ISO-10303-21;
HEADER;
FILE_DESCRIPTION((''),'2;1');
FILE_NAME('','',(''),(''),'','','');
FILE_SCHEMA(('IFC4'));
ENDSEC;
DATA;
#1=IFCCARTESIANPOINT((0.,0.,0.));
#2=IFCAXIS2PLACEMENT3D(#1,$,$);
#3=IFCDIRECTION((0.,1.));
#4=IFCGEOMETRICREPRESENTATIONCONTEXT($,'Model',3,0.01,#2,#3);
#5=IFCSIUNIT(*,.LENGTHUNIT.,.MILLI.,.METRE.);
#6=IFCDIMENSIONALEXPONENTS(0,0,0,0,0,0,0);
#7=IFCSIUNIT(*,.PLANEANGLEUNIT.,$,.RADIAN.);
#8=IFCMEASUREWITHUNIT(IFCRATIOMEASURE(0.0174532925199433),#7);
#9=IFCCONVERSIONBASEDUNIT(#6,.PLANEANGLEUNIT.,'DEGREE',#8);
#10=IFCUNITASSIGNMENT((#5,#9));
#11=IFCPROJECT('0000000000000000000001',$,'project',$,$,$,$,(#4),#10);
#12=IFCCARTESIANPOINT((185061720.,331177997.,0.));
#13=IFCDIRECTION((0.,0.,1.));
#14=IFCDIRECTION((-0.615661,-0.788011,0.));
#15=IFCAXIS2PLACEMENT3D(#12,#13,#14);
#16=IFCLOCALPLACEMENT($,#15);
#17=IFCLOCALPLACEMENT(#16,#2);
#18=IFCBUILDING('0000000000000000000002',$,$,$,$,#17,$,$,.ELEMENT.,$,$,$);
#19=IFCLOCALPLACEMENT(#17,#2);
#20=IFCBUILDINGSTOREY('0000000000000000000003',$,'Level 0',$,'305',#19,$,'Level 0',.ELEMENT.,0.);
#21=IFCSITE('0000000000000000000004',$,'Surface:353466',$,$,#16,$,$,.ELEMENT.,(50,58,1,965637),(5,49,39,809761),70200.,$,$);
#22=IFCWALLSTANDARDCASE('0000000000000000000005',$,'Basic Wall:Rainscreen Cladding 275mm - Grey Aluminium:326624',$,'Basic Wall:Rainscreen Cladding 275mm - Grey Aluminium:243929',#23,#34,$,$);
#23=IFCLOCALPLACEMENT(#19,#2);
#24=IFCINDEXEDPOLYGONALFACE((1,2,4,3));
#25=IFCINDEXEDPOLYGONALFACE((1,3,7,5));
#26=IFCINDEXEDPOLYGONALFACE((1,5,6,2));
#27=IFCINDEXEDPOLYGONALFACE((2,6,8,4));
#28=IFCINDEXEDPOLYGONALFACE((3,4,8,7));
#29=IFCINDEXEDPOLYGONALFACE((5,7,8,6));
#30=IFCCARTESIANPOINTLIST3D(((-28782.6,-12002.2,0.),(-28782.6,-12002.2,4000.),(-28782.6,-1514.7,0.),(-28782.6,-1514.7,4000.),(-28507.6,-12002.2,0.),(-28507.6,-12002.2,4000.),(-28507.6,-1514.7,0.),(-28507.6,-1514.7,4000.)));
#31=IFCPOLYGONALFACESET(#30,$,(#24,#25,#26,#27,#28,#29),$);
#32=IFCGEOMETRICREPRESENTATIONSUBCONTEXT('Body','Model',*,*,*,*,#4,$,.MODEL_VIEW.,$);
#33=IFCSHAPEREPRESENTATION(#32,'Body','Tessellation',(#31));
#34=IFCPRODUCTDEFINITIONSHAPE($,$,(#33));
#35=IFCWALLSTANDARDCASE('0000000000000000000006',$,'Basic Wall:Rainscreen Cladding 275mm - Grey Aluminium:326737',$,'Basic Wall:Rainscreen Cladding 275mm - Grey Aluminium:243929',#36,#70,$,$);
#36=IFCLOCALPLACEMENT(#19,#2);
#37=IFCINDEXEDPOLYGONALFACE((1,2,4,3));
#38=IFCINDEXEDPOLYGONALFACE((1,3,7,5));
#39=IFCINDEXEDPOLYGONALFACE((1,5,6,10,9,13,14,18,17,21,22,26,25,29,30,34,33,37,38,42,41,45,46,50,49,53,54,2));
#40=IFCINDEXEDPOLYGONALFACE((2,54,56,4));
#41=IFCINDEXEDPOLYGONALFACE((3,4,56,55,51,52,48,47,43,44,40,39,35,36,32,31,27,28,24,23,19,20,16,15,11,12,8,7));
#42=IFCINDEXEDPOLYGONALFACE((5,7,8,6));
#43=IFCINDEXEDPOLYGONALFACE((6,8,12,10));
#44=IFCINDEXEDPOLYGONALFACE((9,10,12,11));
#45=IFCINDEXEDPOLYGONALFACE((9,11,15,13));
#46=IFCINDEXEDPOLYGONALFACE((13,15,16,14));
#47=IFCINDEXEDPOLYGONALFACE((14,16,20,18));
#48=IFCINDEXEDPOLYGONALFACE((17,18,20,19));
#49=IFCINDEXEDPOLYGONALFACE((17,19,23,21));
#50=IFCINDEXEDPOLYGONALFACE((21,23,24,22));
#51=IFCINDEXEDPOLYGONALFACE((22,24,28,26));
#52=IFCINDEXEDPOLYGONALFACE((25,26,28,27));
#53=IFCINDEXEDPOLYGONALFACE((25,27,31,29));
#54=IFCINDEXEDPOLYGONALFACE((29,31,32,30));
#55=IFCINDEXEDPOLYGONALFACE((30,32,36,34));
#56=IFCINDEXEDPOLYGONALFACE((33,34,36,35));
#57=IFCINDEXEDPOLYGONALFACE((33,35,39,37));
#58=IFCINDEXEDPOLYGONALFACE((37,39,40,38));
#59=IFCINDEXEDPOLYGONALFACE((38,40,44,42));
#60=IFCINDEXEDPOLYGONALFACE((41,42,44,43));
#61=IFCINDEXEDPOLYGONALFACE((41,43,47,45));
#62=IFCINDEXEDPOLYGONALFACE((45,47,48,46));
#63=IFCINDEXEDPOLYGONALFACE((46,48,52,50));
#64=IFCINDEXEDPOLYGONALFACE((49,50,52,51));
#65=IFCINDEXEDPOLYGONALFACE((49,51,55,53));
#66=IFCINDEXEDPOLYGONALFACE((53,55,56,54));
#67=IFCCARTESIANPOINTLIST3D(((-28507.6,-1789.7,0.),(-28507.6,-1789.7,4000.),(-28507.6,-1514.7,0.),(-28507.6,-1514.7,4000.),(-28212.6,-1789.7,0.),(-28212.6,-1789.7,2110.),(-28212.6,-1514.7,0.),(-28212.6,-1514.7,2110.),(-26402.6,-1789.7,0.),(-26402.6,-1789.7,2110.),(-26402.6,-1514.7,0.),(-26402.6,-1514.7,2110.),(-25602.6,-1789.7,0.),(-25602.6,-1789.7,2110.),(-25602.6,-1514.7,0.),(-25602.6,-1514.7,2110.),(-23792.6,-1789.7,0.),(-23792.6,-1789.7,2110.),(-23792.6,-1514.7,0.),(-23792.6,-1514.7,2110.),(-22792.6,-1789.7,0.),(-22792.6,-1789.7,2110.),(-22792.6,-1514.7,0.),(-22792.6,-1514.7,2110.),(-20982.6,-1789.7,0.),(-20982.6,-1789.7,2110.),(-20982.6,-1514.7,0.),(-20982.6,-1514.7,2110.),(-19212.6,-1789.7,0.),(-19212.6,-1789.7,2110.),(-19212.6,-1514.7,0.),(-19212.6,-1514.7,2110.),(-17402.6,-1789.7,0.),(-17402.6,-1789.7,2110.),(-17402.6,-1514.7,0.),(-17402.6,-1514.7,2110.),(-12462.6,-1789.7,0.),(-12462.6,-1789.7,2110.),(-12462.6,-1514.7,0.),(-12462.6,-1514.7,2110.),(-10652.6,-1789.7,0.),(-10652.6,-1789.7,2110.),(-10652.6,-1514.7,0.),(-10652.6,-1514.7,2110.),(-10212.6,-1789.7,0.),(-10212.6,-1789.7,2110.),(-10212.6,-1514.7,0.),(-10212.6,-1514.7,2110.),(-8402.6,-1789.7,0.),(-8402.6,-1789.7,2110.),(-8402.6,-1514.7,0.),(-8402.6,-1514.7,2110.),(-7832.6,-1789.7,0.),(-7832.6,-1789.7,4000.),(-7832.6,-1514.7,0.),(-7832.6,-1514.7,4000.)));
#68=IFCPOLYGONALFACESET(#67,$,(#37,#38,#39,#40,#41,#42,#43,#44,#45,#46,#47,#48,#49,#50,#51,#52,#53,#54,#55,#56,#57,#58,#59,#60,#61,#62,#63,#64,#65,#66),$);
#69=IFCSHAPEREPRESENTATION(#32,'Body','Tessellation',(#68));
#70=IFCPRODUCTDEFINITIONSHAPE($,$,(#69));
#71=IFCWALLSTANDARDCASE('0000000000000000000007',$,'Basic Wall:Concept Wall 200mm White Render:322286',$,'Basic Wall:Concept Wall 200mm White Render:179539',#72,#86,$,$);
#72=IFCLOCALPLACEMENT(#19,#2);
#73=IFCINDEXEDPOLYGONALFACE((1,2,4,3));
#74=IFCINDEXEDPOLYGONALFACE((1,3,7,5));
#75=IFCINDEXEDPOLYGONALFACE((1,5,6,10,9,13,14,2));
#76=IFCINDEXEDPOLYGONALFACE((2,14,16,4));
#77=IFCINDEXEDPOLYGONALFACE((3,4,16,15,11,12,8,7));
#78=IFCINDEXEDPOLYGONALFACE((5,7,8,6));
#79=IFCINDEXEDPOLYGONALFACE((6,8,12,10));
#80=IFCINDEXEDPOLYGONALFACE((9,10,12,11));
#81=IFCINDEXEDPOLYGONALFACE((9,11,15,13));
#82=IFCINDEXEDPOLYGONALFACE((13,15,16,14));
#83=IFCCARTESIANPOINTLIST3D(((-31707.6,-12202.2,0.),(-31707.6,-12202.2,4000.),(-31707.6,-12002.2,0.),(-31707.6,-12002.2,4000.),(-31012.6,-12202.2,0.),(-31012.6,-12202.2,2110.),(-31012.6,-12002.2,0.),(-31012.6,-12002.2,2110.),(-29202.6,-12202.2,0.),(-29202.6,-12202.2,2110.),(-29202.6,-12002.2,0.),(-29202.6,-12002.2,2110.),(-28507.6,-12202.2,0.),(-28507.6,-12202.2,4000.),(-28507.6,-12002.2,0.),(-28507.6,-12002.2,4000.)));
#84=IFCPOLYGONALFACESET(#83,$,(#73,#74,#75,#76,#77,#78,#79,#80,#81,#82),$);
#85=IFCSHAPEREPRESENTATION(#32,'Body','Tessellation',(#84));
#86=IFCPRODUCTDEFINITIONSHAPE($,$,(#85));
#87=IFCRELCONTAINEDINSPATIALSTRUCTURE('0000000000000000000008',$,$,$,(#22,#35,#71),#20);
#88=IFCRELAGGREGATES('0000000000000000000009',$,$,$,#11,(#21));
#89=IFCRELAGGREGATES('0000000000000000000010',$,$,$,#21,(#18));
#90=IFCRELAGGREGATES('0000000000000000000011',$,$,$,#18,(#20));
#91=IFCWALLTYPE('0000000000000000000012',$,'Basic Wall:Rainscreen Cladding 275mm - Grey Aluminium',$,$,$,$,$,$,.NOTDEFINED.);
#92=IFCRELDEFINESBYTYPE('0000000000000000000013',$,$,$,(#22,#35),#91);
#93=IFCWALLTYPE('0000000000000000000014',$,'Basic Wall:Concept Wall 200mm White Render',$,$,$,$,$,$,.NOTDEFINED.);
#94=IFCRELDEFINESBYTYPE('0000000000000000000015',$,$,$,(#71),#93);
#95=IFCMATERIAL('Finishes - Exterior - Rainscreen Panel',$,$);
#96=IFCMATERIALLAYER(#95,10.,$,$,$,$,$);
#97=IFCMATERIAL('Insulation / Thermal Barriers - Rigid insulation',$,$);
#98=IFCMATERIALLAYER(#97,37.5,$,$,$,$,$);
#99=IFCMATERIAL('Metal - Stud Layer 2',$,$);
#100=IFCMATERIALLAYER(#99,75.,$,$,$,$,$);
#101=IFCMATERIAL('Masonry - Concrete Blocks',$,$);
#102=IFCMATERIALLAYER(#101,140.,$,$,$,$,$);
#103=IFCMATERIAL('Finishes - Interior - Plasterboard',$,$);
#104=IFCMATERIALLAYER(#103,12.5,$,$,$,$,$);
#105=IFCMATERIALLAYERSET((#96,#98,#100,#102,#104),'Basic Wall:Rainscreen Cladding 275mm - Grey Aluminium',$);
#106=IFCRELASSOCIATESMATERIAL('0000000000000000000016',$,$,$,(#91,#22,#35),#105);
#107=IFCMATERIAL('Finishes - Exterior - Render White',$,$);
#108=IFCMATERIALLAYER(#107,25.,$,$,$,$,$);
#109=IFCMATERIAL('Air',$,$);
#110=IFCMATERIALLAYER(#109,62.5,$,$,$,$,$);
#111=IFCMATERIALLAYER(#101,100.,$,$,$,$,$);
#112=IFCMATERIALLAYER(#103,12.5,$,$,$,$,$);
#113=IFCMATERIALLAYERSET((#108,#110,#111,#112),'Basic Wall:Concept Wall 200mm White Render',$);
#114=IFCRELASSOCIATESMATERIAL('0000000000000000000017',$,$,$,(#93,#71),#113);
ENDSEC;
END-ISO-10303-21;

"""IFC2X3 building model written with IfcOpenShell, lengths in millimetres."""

from ifc_helpers import new_model, entity, si_unit, converted_unit, direction, frame, frame_2d, origin, place, context, subcontext, project, spatial, rectangle, extrude, clip, halfspace, material, layer, layer_set, layer_usage, type_object, element, save


model = new_model("IFC2X3")

# Units and contexts
model_context = context("Model", 3, precision=0.01, world=origin(), true_north=direction((0.0, 1.0)))
body_context = subcontext(model_context, "Body", "Model", "MODEL_VIEW")
ifc_project = project(units=[si_unit("LENGTHUNIT", "METRE", prefix="MILLI"), converted_unit("PLANEANGLEUNIT", "DEGREE", entity("IfcRatioMeasure", 0.0174532925199433), si_unit("PLANEANGLEUNIT", "RADIAN"), dimensions=[0, 0, 0, 0, 0, 0, 0])], contexts=[model_context])

# Site, building, storey
site_placement = place(None, frame((185061720.0, 331177997.0, 0.0), z_axis=(0.0, 0.0, 1.0), x_axis=(-0.615661, -0.788011, 0.0)))
site = spatial("IfcSite", under=ifc_project, at=site_placement, Name="Surface:353466", CompositionType="ELEMENT", RefLatitude=(50, 58, 1, 965637), RefLongitude=(5, 49, 39, 809761), RefElevation=70200.0)
building_placement = place(site_placement, origin())
building = spatial("IfcBuilding", under=site, at=building_placement, CompositionType="ELEMENT")
storey_placement = place(building_placement, origin())
storey = spatial("IfcBuildingStorey", under=building, at=storey_placement, Name="Level 0", ObjectType="305", LongName="Level 0", CompositionType="ELEMENT", Elevation=0.0)

# Wall
ifc_material_1 = material(Name="Finishes - Exterior - Rainscreen Panel")
ifc_layer_1 = layer(ifc_material_1, 10.0)
ifc_material_2 = material(Name="Insulation / Thermal Barriers - Rigid insulation")
ifc_layer_2 = layer(ifc_material_2, 37.5)
ifc_material_3 = material(Name="Metal - Stud Layer 2")
ifc_layer_3 = layer(ifc_material_3, 75.0)
ifc_material_4 = material(Name="Masonry - Concrete Blocks")
ifc_layer_4 = layer(ifc_material_4, 140.0)
ifc_material_5 = material(Name="Finishes - Interior - Plasterboard")
ifc_layer_5 = layer(ifc_material_5, 12.5)
ifc_layer_set_1 = layer_set([ifc_layer_1, ifc_layer_2, ifc_layer_3, ifc_layer_4, ifc_layer_5], Name="Basic Wall:Rainscreen Cladding 275mm - Grey Aluminium")
ifc_layer_usage_1 = layer_usage(ifc_layer_set_1, "AXIS2", "NEGATIVE", 137.5)
wall_type_1 = type_object("IfcWallType", Name="Basic Wall:Rainscreen Cladding 275mm - Grey Aluminium", PredefinedType="NOTDEFINED", material=ifc_layer_set_1)
wall_1_placement = place(storey_placement, frame((-28645.1, -12002.2, 0.0), z_axis=(0.0, 0.0, 1.0), x_axis=(0.0, 1.0, 0.0)))
element("IfcWallStandardCase", 1, at=wall_1_placement, inside=storey, type_object=wall_type_1, material=ifc_layer_usage_1, Name="Basic Wall:Rainscreen Cladding 275mm - Grey Aluminium:326624", ObjectType="Basic Wall:Rainscreen Cladding 275mm - Grey Aluminium:243929", context=body_context, shape_type="Clipping", body=[
    clip(extrude(rectangle(XDim=10487.5, YDim=275.0, at=frame_2d((5243.7, 0.0), x_axis=(-1.0, 0.0))), origin(), (0.0, 0.0, 1.0), 4000.0), halfspace(origin(), True)),
])

# Walls, openings
ifc_layer_usage_2 = layer_usage(ifc_layer_set_1, "AXIS2", "NEGATIVE", 137.5)
wall_2_placement = place(storey_placement, frame((-28507.6, -1652.2, 0.0)))
wall_2 = element("IfcWallStandardCase", 2, at=wall_2_placement, inside=storey, type_object=wall_type_1, material=ifc_layer_usage_2, Name="Basic Wall:Rainscreen Cladding 275mm - Grey Aluminium:326737", ObjectType="Basic Wall:Rainscreen Cladding 275mm - Grey Aluminium:243929", context=body_context, shape_type="Clipping", body=[
    clip(extrude(rectangle(XDim=20675.0, YDim=275.0, at=frame_2d((10337.5, 0.0), x_axis=(-1.0, 0.0))), origin(), (0.0, 0.0, 1.0), 4000.0), halfspace(origin(), True)),
])
opening_1_placement = place(wall_2_placement, frame((9295.0, -1661.5, 0.0)))
element("IfcOpeningElement", 3, at=opening_1_placement, cuts=wall_2, ObjectType="Opening", context=body_context, shape_type="SweptSolid", body=[
    extrude(rectangle(XDim=2110.0, YDim=1810.0, at=frame_2d((0.0, 0.0), x_axis=(0.0, 1.0))), frame((905.0, 0.0, 1055.0), z_axis=(0.0, 1.0, 0.0), x_axis=(1.0, 0.0, 0.0)), (0.0, 0.0, 1.0), 3048.0),
])
opening_2_placement = place(wall_2_placement, frame((16045.0, -1661.5, 0.0)))
element("IfcOpeningElement", 4, at=opening_2_placement, cuts=wall_2, ObjectType="Opening", context=body_context, shape_type="SweptSolid", body=[
    extrude(rectangle(XDim=2110.0, YDim=1810.0, at=frame_2d((0.0, 0.0), x_axis=(0.0, 1.0))), frame((905.0, 0.0, 1055.0), z_axis=(0.0, 1.0, 0.0), x_axis=(1.0, 0.0, 0.0)), (0.0, 0.0, 1.0), 3048.0),
])
opening_3_placement = place(wall_2_placement, frame((18295.0, -1661.5, 0.0)))
element("IfcOpeningElement", 5, at=opening_3_placement, cuts=wall_2, ObjectType="Opening", context=body_context, shape_type="SweptSolid", body=[
    extrude(rectangle(XDim=2110.0, YDim=1810.0, at=frame_2d((0.0, 0.0), x_axis=(0.0, 1.0))), frame((905.0, 0.0, 1055.0), z_axis=(0.0, 1.0, 0.0), x_axis=(1.0, 0.0, 0.0)), (0.0, 0.0, 1.0), 3048.0),
])
opening_4_placement = place(wall_2_placement, frame((295.0, -1661.5, 0.0)))
element("IfcOpeningElement", 6, at=opening_4_placement, cuts=wall_2, ObjectType="Opening", context=body_context, shape_type="SweptSolid", body=[
    extrude(rectangle(XDim=2110.0, YDim=1810.0, at=frame_2d((0.0, 0.0), x_axis=(0.0, 1.0))), frame((905.0, 0.0, 1055.0), z_axis=(0.0, 1.0, 0.0), x_axis=(1.0, 0.0, 0.0)), (0.0, 0.0, 1.0), 3048.0),
])
opening_5_placement = place(wall_2_placement, frame((2905.0, -1661.5, 0.0)))
element("IfcOpeningElement", 7, at=opening_5_placement, cuts=wall_2, ObjectType="Opening", context=body_context, shape_type="SweptSolid", body=[
    extrude(rectangle(XDim=2110.0, YDim=1810.0, at=frame_2d((0.0, 0.0), x_axis=(0.0, 1.0))), frame((905.0, 0.0, 1055.0), z_axis=(0.0, 1.0, 0.0), x_axis=(1.0, 0.0, 0.0)), (0.0, 0.0, 1.0), 3048.0),
])
opening_6_placement = place(wall_2_placement, frame((5715.0, -1661.5, 0.0)))
element("IfcOpeningElement", 8, at=opening_6_placement, cuts=wall_2, ObjectType="Opening", context=body_context, shape_type="SweptSolid", body=[
    extrude(rectangle(XDim=2110.0, YDim=1810.0, at=frame_2d((0.0, 0.0), x_axis=(0.0, 1.0))), frame((905.0, 0.0, 1055.0), z_axis=(0.0, 1.0, 0.0), x_axis=(1.0, 0.0, 0.0)), (0.0, 0.0, 1.0), 3048.0),
])
opening_7_placement = place(wall_2_placement, frame((11105.0, 137.5, 0.0)))
element("IfcOpeningElement", 9, at=opening_7_placement, cuts=wall_2, ObjectType="Opening", context=body_context, shape_type="SweptSolid", body=[
    extrude(rectangle(XDim=2110.0, YDim=1810.0, at=frame_2d((1055.0, 905.0), x_axis=(-1.0, 0.0))), frame((0.0, 0.0, 0.0), z_axis=(0.0, -1.0, 0.0), x_axis=(0.0, 0.0, 1.0)), (0.0, 0.0, 1.0), 275.0),
])
opening_8_placement = place(wall_2_placement, frame((17855.0, 137.5, 0.0)))
element("IfcOpeningElement", 10, at=opening_8_placement, cuts=wall_2, ObjectType="Opening", context=body_context, shape_type="SweptSolid", body=[
    extrude(rectangle(XDim=2110.0, YDim=1810.0, at=frame_2d((1055.0, 905.0), x_axis=(-1.0, 0.0))), frame((0.0, 0.0, 0.0), z_axis=(0.0, -1.0, 0.0), x_axis=(0.0, 0.0, 1.0)), (0.0, 0.0, 1.0), 275.0),
])
opening_9_placement = place(wall_2_placement, frame((20105.0, 137.5, 0.0)))
element("IfcOpeningElement", 11, at=opening_9_placement, cuts=wall_2, ObjectType="Opening", context=body_context, shape_type="SweptSolid", body=[
    extrude(rectangle(XDim=2110.0, YDim=1810.0, at=frame_2d((1055.0, 905.0), x_axis=(-1.0, 0.0))), frame((0.0, 0.0, 0.0), z_axis=(0.0, -1.0, 0.0), x_axis=(0.0, 0.0, 1.0)), (0.0, 0.0, 1.0), 275.0),
])
opening_10_placement = place(wall_2_placement, frame((4715.0, 137.5, 0.0)))
element("IfcOpeningElement", 12, at=opening_10_placement, cuts=wall_2, ObjectType="Opening", context=body_context, shape_type="SweptSolid", body=[
    extrude(rectangle(XDim=2110.0, YDim=1810.0, at=frame_2d((1055.0, 905.0), x_axis=(-1.0, 0.0))), frame((0.0, 0.0, 0.0), z_axis=(0.0, -1.0, 0.0), x_axis=(0.0, 0.0, 1.0)), (0.0, 0.0, 1.0), 275.0),
])
opening_11_placement = place(wall_2_placement, frame((2105.0, 137.5, 0.0)))
element("IfcOpeningElement", 13, at=opening_11_placement, cuts=wall_2, ObjectType="Opening", context=body_context, shape_type="SweptSolid", body=[
    extrude(rectangle(XDim=2110.0, YDim=1810.0, at=frame_2d((1055.0, 905.0), x_axis=(-1.0, 0.0))), frame((0.0, 0.0, 0.0), z_axis=(0.0, -1.0, 0.0), x_axis=(0.0, 0.0, 1.0)), (0.0, 0.0, 1.0), 275.0),
])
opening_12_placement = place(wall_2_placement, frame((7525.0, 137.5, 0.0)))
element("IfcOpeningElement", 14, at=opening_12_placement, cuts=wall_2, ObjectType="Opening", context=body_context, shape_type="SweptSolid", body=[
    extrude(rectangle(XDim=2110.0, YDim=1810.0, at=frame_2d((1055.0, 905.0), x_axis=(-1.0, 0.0))), frame((0.0, 0.0, 0.0), z_axis=(0.0, -1.0, 0.0), x_axis=(0.0, 0.0, 1.0)), (0.0, 0.0, 1.0), 275.0),
])
ifc_material_6 = material(Name="Finishes - Exterior - Render White")
ifc_layer_6 = layer(ifc_material_6, 25.0)
ifc_material_7 = material(Name="Air")
ifc_layer_7 = layer(ifc_material_7, 62.5)
ifc_layer_8 = layer(ifc_material_4, 100.0)
ifc_layer_9 = layer(ifc_material_5, 12.5)
ifc_layer_set_2 = layer_set([ifc_layer_6, ifc_layer_7, ifc_layer_8, ifc_layer_9], Name="Basic Wall:Concept Wall 200mm White Render")
ifc_layer_usage_3 = layer_usage(ifc_layer_set_2, "AXIS2", "POSITIVE", -100.0)
wall_type_2 = type_object("IfcWallType", Name="Basic Wall:Concept Wall 200mm White Render", PredefinedType="NOTDEFINED", material=ifc_layer_set_2)
wall_3_placement = place(storey_placement, frame((-28507.6, -12102.2, 0.0), z_axis=(0.0, 0.0, 1.0), x_axis=(-1.0, 0.0, 0.0)))
wall_3 = element("IfcWallStandardCase", 15, at=wall_3_placement, inside=storey, type_object=wall_type_2, material=ifc_layer_usage_3, Name="Basic Wall:Concept Wall 200mm White Render:322286", ObjectType="Basic Wall:Concept Wall 200mm White Render:179539", context=body_context, shape_type="Clipping", body=[
    clip(extrude(rectangle(XDim=3200.0, YDim=200.0, at=frame_2d((1600.0, 0.0), x_axis=(-1.0, 0.0))), origin(), (0.0, 0.0, 1.0), 4000.0), halfspace(origin(), True)),
])
opening_13_placement = place(wall_3_placement, frame((2505.0, 1424.0, 0.0)))
element("IfcOpeningElement", 16, at=opening_13_placement, cuts=wall_3, ObjectType="Opening", context=body_context, shape_type="SweptSolid", body=[
    extrude(rectangle(XDim=2110.0, YDim=1810.0, at=frame_2d((0.0, 0.0), x_axis=(0.0, 1.0))), frame((-905.0, -3048.0, 1055.0), z_axis=(0.0, 1.0, 0.0), x_axis=(1.0, 0.0, 0.0)), (0.0, 0.0, 1.0), 3048.0),
])
opening_14_placement = place(wall_3_placement, frame((2505.0, 100.0, 0.0)))
element("IfcOpeningElement", 17, at=opening_14_placement, cuts=wall_3, ObjectType="Opening", context=body_context, shape_type="SweptSolid", body=[
    extrude(rectangle(XDim=2110.0, YDim=1810.0, at=frame_2d((1055.0, 905.0), x_axis=(-1.0, 0.0))), frame((0.0, 0.0, 0.0), z_axis=(0.0, -1.0, 0.0), x_axis=(0.0, 0.0, 1.0)), (0.0, 0.0, 1.0), 200.0),
])

save(model, "model.ifc")
